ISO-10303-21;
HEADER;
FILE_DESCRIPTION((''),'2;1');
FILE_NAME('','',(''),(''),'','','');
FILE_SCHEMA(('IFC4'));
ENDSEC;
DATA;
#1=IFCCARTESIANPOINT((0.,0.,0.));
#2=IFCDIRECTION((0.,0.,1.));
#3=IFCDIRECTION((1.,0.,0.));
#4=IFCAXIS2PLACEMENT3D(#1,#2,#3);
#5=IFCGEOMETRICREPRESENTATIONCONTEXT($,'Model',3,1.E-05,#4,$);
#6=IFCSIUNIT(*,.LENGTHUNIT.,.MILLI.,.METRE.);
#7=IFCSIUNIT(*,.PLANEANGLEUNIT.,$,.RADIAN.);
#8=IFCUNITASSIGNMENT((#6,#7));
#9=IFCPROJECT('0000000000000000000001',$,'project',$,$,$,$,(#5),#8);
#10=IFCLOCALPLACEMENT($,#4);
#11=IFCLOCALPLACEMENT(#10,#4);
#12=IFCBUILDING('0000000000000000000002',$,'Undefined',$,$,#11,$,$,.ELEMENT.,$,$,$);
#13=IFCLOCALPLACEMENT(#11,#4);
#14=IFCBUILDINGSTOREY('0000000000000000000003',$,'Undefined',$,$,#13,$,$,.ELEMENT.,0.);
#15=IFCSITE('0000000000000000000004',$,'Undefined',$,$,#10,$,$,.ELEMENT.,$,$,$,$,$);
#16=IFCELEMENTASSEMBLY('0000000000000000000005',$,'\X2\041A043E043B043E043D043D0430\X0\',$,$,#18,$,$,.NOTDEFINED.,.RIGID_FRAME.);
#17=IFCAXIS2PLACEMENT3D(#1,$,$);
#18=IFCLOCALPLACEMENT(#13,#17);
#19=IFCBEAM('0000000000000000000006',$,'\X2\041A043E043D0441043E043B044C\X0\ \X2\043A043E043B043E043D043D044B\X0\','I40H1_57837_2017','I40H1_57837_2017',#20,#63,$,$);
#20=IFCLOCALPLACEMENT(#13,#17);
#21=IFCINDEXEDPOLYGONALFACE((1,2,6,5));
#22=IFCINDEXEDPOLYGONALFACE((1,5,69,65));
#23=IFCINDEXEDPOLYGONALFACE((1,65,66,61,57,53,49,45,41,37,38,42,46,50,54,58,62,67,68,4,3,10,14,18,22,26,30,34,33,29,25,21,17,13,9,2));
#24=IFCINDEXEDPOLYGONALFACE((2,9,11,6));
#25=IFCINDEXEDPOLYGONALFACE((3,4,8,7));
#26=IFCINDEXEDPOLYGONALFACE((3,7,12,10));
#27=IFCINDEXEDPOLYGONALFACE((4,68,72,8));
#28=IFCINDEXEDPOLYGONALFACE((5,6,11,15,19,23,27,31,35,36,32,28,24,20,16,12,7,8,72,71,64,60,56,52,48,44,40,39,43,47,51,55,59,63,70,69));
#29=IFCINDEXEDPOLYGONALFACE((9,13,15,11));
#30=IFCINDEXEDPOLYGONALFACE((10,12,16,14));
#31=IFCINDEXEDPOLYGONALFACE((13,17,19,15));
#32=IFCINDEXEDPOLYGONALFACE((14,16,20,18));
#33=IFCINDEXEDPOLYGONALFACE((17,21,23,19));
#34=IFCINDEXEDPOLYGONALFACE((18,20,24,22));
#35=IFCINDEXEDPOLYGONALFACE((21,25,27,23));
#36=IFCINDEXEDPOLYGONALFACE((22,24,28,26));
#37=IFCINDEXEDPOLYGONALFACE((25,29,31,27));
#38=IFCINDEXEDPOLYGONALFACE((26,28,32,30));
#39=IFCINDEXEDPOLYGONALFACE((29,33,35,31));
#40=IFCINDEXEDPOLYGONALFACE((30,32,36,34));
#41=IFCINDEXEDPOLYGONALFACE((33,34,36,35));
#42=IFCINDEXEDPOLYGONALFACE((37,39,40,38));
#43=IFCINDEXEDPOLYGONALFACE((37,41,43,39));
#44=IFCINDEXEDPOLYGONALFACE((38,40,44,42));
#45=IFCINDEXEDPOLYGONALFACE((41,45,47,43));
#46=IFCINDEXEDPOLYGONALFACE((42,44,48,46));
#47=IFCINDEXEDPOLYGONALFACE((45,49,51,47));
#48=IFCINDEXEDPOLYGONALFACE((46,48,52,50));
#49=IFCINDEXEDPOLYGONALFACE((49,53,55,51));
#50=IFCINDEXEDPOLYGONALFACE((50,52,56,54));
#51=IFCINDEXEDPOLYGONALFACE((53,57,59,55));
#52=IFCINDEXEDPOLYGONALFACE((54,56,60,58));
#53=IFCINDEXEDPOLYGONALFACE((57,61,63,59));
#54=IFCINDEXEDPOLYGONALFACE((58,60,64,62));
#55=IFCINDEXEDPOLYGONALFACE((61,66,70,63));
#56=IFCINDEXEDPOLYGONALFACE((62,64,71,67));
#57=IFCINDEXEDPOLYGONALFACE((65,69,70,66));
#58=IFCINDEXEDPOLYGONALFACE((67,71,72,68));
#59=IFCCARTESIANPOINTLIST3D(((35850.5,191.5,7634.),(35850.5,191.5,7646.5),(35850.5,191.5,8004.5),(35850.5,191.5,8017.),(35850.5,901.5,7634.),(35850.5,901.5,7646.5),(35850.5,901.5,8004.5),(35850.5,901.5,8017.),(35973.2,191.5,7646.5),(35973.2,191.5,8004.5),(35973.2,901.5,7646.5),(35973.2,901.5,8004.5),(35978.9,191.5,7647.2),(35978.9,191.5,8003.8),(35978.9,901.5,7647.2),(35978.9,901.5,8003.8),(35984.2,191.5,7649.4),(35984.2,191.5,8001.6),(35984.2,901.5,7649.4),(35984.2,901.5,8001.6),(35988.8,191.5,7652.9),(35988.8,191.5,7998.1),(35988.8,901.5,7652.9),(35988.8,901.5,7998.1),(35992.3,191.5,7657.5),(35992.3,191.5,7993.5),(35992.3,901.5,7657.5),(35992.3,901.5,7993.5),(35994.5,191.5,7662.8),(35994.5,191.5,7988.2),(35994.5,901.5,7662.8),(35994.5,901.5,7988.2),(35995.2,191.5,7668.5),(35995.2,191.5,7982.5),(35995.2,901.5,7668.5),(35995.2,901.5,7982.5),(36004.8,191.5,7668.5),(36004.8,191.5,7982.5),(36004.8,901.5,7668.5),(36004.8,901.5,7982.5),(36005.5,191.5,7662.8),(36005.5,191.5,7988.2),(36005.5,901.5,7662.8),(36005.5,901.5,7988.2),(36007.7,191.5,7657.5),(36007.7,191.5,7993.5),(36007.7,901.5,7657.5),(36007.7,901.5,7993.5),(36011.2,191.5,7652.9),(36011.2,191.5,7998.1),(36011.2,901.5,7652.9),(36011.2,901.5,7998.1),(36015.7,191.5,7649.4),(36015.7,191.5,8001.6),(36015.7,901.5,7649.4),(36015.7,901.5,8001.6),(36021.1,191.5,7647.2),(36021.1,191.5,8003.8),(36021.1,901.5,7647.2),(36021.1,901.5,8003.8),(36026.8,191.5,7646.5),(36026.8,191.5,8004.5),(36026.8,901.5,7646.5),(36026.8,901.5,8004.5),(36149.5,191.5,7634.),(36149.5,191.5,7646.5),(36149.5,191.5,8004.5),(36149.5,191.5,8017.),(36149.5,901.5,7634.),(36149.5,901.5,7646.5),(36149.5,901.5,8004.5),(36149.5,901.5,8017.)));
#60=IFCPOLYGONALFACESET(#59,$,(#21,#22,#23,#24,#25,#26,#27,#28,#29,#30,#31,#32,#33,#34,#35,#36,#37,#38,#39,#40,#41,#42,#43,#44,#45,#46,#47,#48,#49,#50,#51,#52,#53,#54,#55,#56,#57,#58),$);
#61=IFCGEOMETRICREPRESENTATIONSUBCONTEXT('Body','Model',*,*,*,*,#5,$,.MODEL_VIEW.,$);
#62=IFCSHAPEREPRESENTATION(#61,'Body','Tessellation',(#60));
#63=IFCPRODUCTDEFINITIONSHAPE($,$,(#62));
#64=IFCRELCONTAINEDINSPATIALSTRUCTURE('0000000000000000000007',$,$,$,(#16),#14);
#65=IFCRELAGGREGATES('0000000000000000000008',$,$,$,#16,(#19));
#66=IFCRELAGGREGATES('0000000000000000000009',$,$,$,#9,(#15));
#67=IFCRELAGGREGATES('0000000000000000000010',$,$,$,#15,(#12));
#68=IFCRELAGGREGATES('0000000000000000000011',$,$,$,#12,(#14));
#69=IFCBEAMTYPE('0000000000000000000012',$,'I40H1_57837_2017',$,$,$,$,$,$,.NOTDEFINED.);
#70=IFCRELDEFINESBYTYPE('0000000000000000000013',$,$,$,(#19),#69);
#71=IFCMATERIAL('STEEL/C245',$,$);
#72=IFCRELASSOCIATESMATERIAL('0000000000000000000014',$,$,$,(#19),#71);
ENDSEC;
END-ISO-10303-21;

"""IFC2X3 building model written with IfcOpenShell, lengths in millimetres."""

from ifc_helpers import new_model, si_unit, frame, origin_with_axes, origin_2d_with_axis, place, context, subcontext, project, spatial, i_section, extrude, material, type_object, element, aggregate, save


model = new_model("IFC2X3")

# Units and contexts
model_context = context("Model", 3, precision=1e-05, world=origin_with_axes())
body_context = subcontext(model_context, "Body", "Model", "MODEL_VIEW")
ifc_project = project(units=[si_unit("LENGTHUNIT", "METRE", prefix="MILLI"), si_unit("PLANEANGLEUNIT", "RADIAN")], contexts=[model_context])

# Site, building, storey
site_placement = place(None, origin_with_axes())
site = spatial("IfcSite", under=ifc_project, at=site_placement, Name="Undefined", CompositionType="ELEMENT")
building_placement = place(site_placement, origin_with_axes())
building = spatial("IfcBuilding", under=site, at=building_placement, Name="Undefined", CompositionType="ELEMENT")
storey_placement = place(building_placement, origin_with_axes())
storey = spatial("IfcBuildingStorey", under=building, at=storey_placement, Name="Undefined", CompositionType="ELEMENT", Elevation=0.0)

# Shared definitions
ifc_material_1 = material(Name="STEEL/C245")

# Element assembly
assembly_1_placement = place(storey_placement, origin_with_axes())
assembly_1 = element("IfcElementAssembly", 1, at=assembly_1_placement, inside=storey, Name="Колонна", AssemblyPlace="NOTDEFINED", PredefinedType="RIGID_FRAME")

# Shared definitions
beam_type_1 = type_object("IfcBeamType", Name="I40H1_57837_2017", PredefinedType="NOTDEFINED")

# Beam
beam_1_placement = place(assembly_1_placement, frame((36000.0, 901.5, 7825.5), z_axis=(0.0, 0.0, 1.0), x_axis=(0.0, -1.0, 0.0)))
beam_1 = element("IfcBeam", 2, at=beam_1_placement, type_object=beam_type_1, material=ifc_material_1, Name="Консоль колонны", Description="I40H1_57837_2017", ObjectType="I40H1_57837_2017", context=body_context, shape_type="SweptSolid", body=[
    extrude(i_section(OverallWidth=299.0, OverallDepth=383.0, WebThickness=9.5, FlangeThickness=12.5, FilletRadius=22.0, at=origin_2d_with_axis()), frame((710.0, 0.0, 0.0), z_axis=(-1.0, 0.0, 0.0), x_axis=(0.0, -1.0, 0.0)), (0.0, 0.0, 1.0), 710.0),
])
aggregate(assembly_1, [beam_1])

save(model, "model.ifc")
